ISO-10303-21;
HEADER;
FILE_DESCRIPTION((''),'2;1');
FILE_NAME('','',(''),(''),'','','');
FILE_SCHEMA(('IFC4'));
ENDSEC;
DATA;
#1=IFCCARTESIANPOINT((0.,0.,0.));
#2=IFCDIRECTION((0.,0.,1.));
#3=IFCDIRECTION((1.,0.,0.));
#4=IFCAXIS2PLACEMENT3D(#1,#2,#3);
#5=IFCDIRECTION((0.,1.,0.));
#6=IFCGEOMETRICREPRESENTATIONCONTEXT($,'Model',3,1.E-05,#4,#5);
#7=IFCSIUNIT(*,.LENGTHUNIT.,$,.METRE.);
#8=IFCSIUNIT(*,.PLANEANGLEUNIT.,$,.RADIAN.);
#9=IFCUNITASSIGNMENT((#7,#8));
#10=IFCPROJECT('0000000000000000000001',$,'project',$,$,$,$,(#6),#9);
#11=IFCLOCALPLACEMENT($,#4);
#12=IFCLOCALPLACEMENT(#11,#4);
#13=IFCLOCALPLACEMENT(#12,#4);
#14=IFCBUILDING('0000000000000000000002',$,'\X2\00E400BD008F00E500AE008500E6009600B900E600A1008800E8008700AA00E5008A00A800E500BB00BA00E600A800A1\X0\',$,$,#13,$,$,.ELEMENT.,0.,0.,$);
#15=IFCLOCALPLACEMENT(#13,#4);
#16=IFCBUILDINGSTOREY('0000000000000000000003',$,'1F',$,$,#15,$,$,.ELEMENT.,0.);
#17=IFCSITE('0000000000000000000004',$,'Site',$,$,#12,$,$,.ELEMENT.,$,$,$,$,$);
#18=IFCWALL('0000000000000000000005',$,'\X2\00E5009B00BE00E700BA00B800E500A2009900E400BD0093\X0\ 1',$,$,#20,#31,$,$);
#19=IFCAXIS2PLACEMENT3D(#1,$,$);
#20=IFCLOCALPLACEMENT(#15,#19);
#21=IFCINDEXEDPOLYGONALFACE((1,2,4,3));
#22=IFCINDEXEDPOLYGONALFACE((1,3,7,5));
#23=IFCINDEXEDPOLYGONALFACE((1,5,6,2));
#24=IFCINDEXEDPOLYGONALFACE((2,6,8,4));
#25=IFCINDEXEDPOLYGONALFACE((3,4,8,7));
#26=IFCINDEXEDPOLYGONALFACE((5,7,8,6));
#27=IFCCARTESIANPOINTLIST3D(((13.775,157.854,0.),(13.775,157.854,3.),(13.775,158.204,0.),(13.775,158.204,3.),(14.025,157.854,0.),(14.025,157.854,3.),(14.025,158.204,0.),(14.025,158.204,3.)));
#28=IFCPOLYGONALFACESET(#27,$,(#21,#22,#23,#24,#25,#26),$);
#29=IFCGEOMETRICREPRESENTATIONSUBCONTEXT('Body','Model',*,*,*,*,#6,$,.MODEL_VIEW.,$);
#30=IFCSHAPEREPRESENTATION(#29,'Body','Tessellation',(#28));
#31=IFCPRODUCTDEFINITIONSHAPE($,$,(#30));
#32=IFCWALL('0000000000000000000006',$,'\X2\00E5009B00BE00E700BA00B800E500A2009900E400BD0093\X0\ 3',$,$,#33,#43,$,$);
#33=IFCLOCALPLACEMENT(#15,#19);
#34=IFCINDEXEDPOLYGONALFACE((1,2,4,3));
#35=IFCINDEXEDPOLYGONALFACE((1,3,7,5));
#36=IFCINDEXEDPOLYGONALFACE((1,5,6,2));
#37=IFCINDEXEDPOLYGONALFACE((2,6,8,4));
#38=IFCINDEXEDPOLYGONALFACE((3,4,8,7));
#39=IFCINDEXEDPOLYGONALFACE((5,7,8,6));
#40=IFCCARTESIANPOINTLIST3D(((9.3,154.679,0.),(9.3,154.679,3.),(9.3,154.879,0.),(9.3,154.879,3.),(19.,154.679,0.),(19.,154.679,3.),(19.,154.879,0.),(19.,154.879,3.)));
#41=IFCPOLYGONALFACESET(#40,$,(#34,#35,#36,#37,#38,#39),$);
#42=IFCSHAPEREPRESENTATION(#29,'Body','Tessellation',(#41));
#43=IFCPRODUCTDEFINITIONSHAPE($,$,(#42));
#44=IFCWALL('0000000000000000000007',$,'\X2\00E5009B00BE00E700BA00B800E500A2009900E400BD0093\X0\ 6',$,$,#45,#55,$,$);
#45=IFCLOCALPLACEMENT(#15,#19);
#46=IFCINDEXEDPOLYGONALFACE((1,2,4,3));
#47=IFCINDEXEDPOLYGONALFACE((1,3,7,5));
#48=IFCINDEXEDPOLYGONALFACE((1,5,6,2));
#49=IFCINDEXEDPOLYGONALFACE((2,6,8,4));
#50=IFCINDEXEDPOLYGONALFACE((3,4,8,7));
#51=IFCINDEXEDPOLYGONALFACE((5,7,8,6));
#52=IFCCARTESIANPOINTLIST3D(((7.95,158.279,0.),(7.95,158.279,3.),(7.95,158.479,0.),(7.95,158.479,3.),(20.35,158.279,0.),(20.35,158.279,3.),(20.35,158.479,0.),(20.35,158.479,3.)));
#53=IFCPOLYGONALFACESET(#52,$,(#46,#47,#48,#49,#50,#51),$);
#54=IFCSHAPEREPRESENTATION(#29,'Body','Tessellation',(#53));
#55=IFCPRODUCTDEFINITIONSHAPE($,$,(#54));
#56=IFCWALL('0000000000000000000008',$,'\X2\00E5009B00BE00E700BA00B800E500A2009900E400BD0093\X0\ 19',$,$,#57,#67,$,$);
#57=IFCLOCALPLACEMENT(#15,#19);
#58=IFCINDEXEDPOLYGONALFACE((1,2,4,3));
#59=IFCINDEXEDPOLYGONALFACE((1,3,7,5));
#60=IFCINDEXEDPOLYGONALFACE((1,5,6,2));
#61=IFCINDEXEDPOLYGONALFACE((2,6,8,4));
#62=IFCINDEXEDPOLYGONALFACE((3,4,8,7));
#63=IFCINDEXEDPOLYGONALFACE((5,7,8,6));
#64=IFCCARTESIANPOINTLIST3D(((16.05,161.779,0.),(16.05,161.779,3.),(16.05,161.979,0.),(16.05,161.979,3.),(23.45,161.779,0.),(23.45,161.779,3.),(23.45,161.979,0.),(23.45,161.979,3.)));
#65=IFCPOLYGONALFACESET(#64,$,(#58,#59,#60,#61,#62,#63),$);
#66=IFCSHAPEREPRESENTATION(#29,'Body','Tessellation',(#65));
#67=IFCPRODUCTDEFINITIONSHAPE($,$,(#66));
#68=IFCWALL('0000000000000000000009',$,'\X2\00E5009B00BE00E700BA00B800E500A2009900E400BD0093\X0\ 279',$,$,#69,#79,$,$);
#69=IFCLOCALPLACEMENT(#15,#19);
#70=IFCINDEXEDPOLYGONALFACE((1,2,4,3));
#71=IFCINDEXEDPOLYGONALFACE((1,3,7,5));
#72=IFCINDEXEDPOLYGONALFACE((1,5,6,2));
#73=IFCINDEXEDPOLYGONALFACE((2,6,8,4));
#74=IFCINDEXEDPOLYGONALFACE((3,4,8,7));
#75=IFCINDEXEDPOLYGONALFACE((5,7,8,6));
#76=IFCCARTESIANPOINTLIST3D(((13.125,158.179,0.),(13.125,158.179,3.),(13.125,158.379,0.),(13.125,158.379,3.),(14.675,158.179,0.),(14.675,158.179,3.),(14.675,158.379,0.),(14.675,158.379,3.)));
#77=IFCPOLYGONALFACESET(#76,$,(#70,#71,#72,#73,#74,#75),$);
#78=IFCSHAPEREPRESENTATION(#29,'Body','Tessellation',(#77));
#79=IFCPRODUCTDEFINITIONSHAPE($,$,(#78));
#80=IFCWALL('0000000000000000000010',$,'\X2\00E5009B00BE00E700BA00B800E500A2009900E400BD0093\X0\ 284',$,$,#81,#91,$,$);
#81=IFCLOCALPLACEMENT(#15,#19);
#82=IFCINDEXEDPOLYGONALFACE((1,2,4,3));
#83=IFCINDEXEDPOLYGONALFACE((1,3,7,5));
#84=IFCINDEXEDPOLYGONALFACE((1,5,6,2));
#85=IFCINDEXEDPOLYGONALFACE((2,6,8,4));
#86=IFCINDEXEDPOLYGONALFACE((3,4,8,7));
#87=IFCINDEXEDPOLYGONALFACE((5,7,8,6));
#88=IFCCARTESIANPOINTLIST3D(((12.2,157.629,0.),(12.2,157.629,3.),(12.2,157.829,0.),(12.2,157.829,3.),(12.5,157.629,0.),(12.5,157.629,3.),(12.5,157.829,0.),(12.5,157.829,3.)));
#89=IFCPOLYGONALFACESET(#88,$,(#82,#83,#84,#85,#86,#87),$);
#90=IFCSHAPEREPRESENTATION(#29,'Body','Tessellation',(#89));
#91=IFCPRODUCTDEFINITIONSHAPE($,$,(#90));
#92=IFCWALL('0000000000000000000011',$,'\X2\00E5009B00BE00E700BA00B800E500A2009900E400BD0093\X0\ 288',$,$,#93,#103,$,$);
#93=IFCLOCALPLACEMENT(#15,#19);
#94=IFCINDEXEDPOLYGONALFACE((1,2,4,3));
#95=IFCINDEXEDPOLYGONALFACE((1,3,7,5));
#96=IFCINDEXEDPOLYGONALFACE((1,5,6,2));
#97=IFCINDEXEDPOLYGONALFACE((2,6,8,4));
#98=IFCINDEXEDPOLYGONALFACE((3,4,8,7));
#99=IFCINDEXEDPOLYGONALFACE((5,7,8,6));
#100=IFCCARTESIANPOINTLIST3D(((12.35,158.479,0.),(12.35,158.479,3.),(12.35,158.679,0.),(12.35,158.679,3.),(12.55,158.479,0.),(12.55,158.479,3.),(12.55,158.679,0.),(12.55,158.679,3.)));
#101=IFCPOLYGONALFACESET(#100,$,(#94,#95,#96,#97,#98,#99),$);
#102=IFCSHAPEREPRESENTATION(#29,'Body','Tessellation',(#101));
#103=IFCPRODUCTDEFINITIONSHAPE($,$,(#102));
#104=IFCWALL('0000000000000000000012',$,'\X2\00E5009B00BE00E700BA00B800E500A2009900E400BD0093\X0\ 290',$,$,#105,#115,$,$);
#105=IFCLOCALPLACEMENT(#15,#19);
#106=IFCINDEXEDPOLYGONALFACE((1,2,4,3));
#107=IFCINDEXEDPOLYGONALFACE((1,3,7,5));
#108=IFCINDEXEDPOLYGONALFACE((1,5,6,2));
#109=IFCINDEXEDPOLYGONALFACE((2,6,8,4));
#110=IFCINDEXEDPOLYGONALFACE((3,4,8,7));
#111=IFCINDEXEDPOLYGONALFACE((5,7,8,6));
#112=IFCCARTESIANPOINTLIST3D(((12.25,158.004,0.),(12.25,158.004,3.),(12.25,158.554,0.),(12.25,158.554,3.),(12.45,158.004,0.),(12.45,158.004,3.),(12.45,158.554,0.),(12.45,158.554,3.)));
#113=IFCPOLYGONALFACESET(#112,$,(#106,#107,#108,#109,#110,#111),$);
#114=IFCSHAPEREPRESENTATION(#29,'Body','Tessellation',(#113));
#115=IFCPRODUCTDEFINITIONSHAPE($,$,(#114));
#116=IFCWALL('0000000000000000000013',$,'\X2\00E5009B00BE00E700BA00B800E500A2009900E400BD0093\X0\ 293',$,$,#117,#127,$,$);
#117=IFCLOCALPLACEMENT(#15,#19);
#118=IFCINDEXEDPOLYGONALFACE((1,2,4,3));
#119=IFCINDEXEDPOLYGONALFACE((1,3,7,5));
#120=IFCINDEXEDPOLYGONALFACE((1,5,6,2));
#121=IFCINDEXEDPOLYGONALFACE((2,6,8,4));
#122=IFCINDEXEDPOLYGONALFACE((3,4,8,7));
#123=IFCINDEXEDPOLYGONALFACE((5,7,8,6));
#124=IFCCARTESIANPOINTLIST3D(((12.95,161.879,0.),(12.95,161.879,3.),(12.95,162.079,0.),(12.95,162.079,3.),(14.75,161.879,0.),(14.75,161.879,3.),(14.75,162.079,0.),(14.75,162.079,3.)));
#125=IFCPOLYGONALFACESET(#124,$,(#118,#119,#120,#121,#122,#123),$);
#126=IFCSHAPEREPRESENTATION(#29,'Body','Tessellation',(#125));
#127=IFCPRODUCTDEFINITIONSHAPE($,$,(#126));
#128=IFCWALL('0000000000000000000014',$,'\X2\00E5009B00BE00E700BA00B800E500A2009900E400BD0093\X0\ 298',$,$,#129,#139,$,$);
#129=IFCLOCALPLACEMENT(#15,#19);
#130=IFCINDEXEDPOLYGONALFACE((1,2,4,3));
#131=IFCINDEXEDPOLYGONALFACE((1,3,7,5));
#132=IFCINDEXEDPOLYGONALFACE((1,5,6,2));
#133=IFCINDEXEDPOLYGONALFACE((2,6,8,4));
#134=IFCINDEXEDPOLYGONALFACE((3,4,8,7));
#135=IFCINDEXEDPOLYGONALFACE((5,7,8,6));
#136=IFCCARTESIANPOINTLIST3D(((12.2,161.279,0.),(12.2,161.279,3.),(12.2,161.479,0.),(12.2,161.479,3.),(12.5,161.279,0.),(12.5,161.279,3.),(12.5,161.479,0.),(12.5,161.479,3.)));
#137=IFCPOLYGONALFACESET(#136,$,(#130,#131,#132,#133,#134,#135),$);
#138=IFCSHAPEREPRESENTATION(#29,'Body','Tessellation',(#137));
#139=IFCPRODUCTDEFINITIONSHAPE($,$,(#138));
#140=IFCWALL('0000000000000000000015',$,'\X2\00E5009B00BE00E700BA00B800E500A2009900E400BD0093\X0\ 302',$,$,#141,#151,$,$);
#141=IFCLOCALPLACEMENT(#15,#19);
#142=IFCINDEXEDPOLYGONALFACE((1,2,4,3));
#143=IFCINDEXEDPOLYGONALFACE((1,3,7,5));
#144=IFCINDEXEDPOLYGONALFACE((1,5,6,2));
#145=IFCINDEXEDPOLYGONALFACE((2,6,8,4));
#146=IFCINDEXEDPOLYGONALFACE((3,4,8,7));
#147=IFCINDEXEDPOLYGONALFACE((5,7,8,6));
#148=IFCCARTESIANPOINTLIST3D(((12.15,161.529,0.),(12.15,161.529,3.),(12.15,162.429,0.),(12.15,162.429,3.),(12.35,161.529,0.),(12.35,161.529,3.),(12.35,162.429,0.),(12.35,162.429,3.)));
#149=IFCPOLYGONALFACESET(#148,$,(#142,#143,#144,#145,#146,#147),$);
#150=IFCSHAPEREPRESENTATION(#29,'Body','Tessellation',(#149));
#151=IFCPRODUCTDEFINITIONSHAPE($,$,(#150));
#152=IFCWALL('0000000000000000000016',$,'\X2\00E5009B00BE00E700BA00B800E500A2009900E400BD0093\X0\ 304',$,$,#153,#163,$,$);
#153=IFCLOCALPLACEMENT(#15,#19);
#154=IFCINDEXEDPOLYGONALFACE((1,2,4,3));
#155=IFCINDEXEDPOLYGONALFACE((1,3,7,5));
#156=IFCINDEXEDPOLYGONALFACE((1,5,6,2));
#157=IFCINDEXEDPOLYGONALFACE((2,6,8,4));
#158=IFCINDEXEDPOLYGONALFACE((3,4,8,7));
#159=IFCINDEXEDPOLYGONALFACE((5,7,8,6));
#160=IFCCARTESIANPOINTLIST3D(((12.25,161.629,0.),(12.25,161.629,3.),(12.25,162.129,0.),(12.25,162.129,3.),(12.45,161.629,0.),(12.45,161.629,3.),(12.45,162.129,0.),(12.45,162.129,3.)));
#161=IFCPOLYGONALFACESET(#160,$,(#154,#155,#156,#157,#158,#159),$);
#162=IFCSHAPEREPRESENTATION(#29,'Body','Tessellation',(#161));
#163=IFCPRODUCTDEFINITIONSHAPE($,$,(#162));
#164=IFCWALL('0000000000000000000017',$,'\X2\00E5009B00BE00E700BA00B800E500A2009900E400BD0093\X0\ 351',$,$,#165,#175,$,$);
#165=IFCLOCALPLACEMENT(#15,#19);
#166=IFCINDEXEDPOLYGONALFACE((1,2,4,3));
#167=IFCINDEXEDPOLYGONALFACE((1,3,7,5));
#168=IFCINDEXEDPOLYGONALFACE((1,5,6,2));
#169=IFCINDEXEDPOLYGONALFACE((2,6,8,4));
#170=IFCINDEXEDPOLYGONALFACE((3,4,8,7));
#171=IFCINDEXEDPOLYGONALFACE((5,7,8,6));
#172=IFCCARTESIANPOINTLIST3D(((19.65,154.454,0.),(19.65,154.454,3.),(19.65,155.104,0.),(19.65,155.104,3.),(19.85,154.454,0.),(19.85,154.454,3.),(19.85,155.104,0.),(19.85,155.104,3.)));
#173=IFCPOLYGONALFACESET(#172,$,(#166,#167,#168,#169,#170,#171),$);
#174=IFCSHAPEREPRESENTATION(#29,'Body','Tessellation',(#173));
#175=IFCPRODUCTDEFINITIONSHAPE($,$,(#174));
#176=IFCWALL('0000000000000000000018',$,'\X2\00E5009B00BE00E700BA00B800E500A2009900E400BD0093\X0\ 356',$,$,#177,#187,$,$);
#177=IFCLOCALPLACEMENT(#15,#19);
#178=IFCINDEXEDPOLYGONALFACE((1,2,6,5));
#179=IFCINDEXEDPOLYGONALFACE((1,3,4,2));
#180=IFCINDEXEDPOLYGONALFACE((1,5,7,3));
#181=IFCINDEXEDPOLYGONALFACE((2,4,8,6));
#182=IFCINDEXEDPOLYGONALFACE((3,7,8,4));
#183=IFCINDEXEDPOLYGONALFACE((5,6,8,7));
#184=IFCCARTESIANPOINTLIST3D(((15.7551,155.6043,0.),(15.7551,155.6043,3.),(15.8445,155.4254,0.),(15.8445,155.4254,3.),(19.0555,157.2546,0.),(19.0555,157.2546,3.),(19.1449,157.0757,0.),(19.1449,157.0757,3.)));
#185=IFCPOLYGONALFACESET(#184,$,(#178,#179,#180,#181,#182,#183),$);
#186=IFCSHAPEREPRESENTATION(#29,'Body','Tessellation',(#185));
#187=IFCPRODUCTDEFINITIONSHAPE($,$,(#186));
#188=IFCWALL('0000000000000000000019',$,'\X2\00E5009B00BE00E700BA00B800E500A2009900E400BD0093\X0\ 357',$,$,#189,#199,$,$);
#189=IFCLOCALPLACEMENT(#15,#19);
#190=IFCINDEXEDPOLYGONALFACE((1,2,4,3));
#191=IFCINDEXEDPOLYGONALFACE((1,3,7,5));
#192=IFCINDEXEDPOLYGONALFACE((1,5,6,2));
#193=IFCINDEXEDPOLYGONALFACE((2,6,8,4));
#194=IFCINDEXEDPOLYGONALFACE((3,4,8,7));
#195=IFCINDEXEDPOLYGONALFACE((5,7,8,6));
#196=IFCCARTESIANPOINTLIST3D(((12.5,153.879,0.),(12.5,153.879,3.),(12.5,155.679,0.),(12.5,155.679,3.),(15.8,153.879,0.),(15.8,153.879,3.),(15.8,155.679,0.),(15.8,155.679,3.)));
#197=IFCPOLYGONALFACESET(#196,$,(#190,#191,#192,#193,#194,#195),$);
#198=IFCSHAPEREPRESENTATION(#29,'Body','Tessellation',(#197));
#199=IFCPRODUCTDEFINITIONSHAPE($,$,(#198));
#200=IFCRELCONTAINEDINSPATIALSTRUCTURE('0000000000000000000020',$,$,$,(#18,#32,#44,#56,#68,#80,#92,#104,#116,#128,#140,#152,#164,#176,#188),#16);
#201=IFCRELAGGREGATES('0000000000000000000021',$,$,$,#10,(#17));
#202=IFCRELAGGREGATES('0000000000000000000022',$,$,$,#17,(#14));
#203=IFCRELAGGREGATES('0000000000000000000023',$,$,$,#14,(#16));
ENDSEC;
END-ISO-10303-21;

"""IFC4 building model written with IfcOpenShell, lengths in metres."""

from ifc_helpers import new_model, si_unit, direction, frame, frame_2d, origin_with_axes, place, context, subcontext, project, spatial, rectangle, extrude, element, save


model = new_model("IFC4")

# Units and contexts
model_context = context("Model", 3, precision=1e-05, world=origin_with_axes(), true_north=direction((0.0, 1.0, 0.0)))
body_context = subcontext(model_context, "Body", "Model", "MODEL_VIEW")
ifc_project = project(units=[si_unit("LENGTHUNIT", "METRE"), si_unit("PLANEANGLEUNIT", "RADIAN")], contexts=[model_context])

# Site, building, storey
placement = place(None, origin_with_axes())
site_placement = place(placement, origin_with_axes())
site = spatial("IfcSite", under=ifc_project, at=site_placement, Name="Site", CompositionType="ELEMENT")
building_placement = place(site_placement, origin_with_axes())
building = spatial("IfcBuilding", under=site, at=building_placement, Name="ä½\u008få®\u0085æ\u0096¹æ¡\u0088è\u0087ªå\u008a¨å»ºæ¨¡", CompositionType="ELEMENT", ElevationOfRefHeight=0.0, ElevationOfTerrain=0.0)
storey_placement = place(building_placement, origin_with_axes())
storey = spatial("IfcBuildingStorey", under=building, at=storey_placement, Name="1F", CompositionType="ELEMENT", Elevation=0.0)

# Walls
wall_1_placement = place(storey_placement, frame((13.9, 158.029, 0.0), z_axis=(0.0, 0.0, 1.0), x_axis=(1.0, 0.0, 0.0)))
element("IfcWall", 1, at=wall_1_placement, inside=storey, Name="å\u009b¾çº¸å¢\u0099ä½\u0093 1", context=body_context, shape_type="SweptSolid", body=[
    extrude(rectangle(XDim=0.25, YDim=0.35, at=frame_2d((0.0, 0.0), x_axis=(1.0, 0.0, 0.0))), frame((0.0, 0.0, 0.0), z_axis=(0.0, 0.0, 1.0)), (0.0, 0.0, 1.0), 3.0),
])
for number, where, z_axis, x_axis, name in (
    (2, (14.15, 154.779, 0.0), (0.0, 0.0, 1.0), (-1.0, 0.0, 0.0), "å\u009b¾çº¸å¢\u0099ä½\u0093 3"),
):
    element("IfcWall", number, at=place(storey_placement, frame(where, z_axis=z_axis, x_axis=x_axis)), inside=storey, Name=name, context=body_context, shape_type="SweptSolid", body=[
        extrude(rectangle(XDim=9.7, YDim=0.2, at=frame_2d((0.0, 0.0), x_axis=(1.0, 0.0, 0.0))), frame((0.0, 0.0, 0.0), z_axis=(0.0, 0.0, 1.0)), (0.0, 0.0, 1.0), 3.0),
    ])
wall_2_placement = place(storey_placement, frame((14.15, 158.379, 0.0), z_axis=(0.0, 0.0, 1.0), x_axis=(-1.0, 0.0, 0.0)))
element("IfcWall", 3, at=wall_2_placement, inside=storey, Name="å\u009b¾çº¸å¢\u0099ä½\u0093 6", context=body_context, shape_type="SweptSolid", body=[
    extrude(rectangle(XDim=12.4, YDim=0.2, at=frame_2d((0.0, 0.0), x_axis=(1.0, 0.0, 0.0))), frame((0.0, 0.0, 0.0), z_axis=(0.0, 0.0, 1.0)), (0.0, 0.0, 1.0), 3.0),
])
wall_3_placement = place(storey_placement, frame((19.75, 161.879, 0.0), z_axis=(0.0, 0.0, 1.0), x_axis=(-1.0, 0.0, 0.0)))
element("IfcWall", 4, at=wall_3_placement, inside=storey, Name="å\u009b¾çº¸å¢\u0099ä½\u0093 19", context=body_context, shape_type="SweptSolid", body=[
    extrude(rectangle(XDim=7.4, YDim=0.2, at=frame_2d((0.0, 0.0), x_axis=(1.0, 0.0, 0.0))), frame((0.0, 0.0, 0.0), z_axis=(0.0, 0.0, 1.0)), (0.0, 0.0, 1.0), 3.0),
])
wall_4_placement = place(storey_placement, frame((13.9, 158.279, 0.0), z_axis=(0.0, 0.0, 1.0), x_axis=(-1.0, 0.0, 0.0)))
element("IfcWall", 5, at=wall_4_placement, inside=storey, Name="å\u009b¾çº¸å¢\u0099ä½\u0093 279", context=body_context, shape_type="SweptSolid", body=[
    extrude(rectangle(XDim=1.55, YDim=0.2, at=frame_2d((0.0, 0.0), x_axis=(1.0, 0.0, 0.0))), frame((0.0, 0.0, 0.0), z_axis=(0.0, 0.0, 1.0)), (0.0, 0.0, 1.0), 3.0),
])
wall_5_placement = place(storey_placement, frame((12.35, 157.729, 0.0), z_axis=(0.0, 0.0, 1.0), x_axis=(-1.0, 0.0, 0.0)))
element("IfcWall", 6, at=wall_5_placement, inside=storey, Name="å\u009b¾çº¸å¢\u0099ä½\u0093 284", context=body_context, shape_type="SweptSolid", body=[
    extrude(rectangle(XDim=0.3, YDim=0.2, at=frame_2d((0.0, 0.0), x_axis=(1.0, 0.0, 0.0))), frame((0.0, 0.0, 0.0), z_axis=(0.0, 0.0, 1.0)), (0.0, 0.0, 1.0), 3.0),
])
for number, where, z_axis, x_axis, name in (
    (7, (12.45, 158.579, 0.0), (0.0, 0.0, 1.0), (-1.0, 0.0, 0.0), "å\u009b¾çº¸å¢\u0099ä½\u0093 288"),
):
    element("IfcWall", number, at=place(storey_placement, frame(where, z_axis=z_axis, x_axis=x_axis)), inside=storey, Name=name, context=body_context, shape_type="SweptSolid", body=[
        extrude(rectangle(XDim=0.2, YDim=0.2, at=frame_2d((0.0, 0.0), x_axis=(1.0, 0.0, 0.0))), frame((0.0, 0.0, 0.0), z_axis=(0.0, 0.0, 1.0)), (0.0, 0.0, 1.0), 3.0),
    ])
wall_6_placement = place(storey_placement, frame((12.35, 158.279, 0.0), z_axis=(0.0, 0.0, 1.0), x_axis=(0.0, -1.0, 0.0)))
element("IfcWall", 8, at=wall_6_placement, inside=storey, Name="å\u009b¾çº¸å¢\u0099ä½\u0093 290", context=body_context, shape_type="SweptSolid", body=[
    extrude(rectangle(XDim=0.55, YDim=0.2, at=frame_2d((0.0, 0.0), x_axis=(1.0, 0.0, 0.0))), frame((0.0, 0.0, 0.0), z_axis=(0.0, 0.0, 1.0)), (0.0, 0.0, 1.0), 3.0),
])
wall_7_placement = place(storey_placement, frame((13.85, 161.979, 0.0), z_axis=(0.0, 0.0, 1.0), x_axis=(-1.0, 0.0, 0.0)))
element("IfcWall", 9, at=wall_7_placement, inside=storey, Name="å\u009b¾çº¸å¢\u0099ä½\u0093 293", context=body_context, shape_type="SweptSolid", body=[
    extrude(rectangle(XDim=1.8, YDim=0.2, at=frame_2d((0.0, 0.0), x_axis=(1.0, 0.0, 0.0))), frame((0.0, 0.0, 0.0), z_axis=(0.0, 0.0, 1.0)), (0.0, 0.0, 1.0), 3.0),
])
wall_8_placement = place(storey_placement, frame((12.35, 161.379, 0.0), z_axis=(0.0, 0.0, 1.0), x_axis=(-1.0, 0.0, 0.0)))
element("IfcWall", 10, at=wall_8_placement, inside=storey, Name="å\u009b¾çº¸å¢\u0099ä½\u0093 298", context=body_context, shape_type="SweptSolid", body=[
    extrude(rectangle(XDim=0.3, YDim=0.2, at=frame_2d((0.0, 0.0), x_axis=(1.0, 0.0, 0.0))), frame((0.0, 0.0, 0.0), z_axis=(0.0, 0.0, 1.0)), (0.0, 0.0, 1.0), 3.0),
])
wall_9_placement = place(storey_placement, frame((12.25, 161.979, 0.0), z_axis=(0.0, 0.0, 1.0), x_axis=(0.0, 1.0, 0.0)))
element("IfcWall", 11, at=wall_9_placement, inside=storey, Name="å\u009b¾çº¸å¢\u0099ä½\u0093 302", context=body_context, shape_type="SweptSolid", body=[
    extrude(rectangle(XDim=0.9, YDim=0.2, at=frame_2d((0.0, 0.0), x_axis=(1.0, 0.0, 0.0))), frame((0.0, 0.0, 0.0), z_axis=(0.0, 0.0, 1.0)), (0.0, 0.0, 1.0), 3.0),
])
wall_10_placement = place(storey_placement, frame((12.35, 161.879, 0.0), z_axis=(0.0, 0.0, 1.0), x_axis=(0.0, -1.0, 0.0)))
element("IfcWall", 12, at=wall_10_placement, inside=storey, Name="å\u009b¾çº¸å¢\u0099ä½\u0093 304", context=body_context, shape_type="SweptSolid", body=[
    extrude(rectangle(XDim=0.5, YDim=0.2, at=frame_2d((0.0, 0.0), x_axis=(1.0, 0.0, 0.0))), frame((0.0, 0.0, 0.0), z_axis=(0.0, 0.0, 1.0)), (0.0, 0.0, 1.0), 3.0),
])
wall_11_placement = place(storey_placement, frame((19.75, 154.779, 0.0), z_axis=(0.0, 0.0, 1.0), x_axis=(0.0, -1.0, 0.0)))
element("IfcWall", 13, at=wall_11_placement, inside=storey, Name="å\u009b¾çº¸å¢\u0099ä½\u0093 351", context=body_context, shape_type="SweptSolid", body=[
    extrude(rectangle(XDim=0.65, YDim=0.2, at=frame_2d((0.0, 0.0), x_axis=(1.0, 0.0, 0.0))), frame((0.0, 0.0, 0.0), z_axis=(0.0, 0.0, 1.0)), (0.0, 0.0, 1.0), 3.0),
])
wall_12_placement = place(storey_placement, frame((17.45, 156.34, 0.0), z_axis=(0.0, 0.0, 1.0), x_axis=(-0.894428, -0.447213, 0.0)))
element("IfcWall", 14, at=wall_12_placement, inside=storey, Name="å\u009b¾çº¸å¢\u0099ä½\u0093 356", context=body_context, shape_type="SweptSolid", body=[
    extrude(rectangle(XDim=3.69, YDim=0.2, at=frame_2d((0.0, 0.0), x_axis=(1.0, 0.0, 0.0))), frame((0.0, 0.0, 0.0), z_axis=(0.0, 0.0, 1.0)), (0.0, 0.0, 1.0), 3.0),
])
wall_13_placement = place(storey_placement, frame((14.15, 154.779, 0.0), z_axis=(0.0, 0.0, 1.0), x_axis=(1.0, 0.0, 0.0)))
element("IfcWall", 15, at=wall_13_placement, inside=storey, Name="å\u009b¾çº¸å¢\u0099ä½\u0093 357", context=body_context, shape_type="SweptSolid", body=[
    extrude(rectangle(XDim=3.3, YDim=1.8, at=frame_2d((0.0, 0.0), x_axis=(1.0, 0.0, 0.0))), frame((0.0, 0.0, 0.0), z_axis=(0.0, 0.0, 1.0)), (0.0, 0.0, 1.0), 3.0),
])

save(model, "model.ifc")
